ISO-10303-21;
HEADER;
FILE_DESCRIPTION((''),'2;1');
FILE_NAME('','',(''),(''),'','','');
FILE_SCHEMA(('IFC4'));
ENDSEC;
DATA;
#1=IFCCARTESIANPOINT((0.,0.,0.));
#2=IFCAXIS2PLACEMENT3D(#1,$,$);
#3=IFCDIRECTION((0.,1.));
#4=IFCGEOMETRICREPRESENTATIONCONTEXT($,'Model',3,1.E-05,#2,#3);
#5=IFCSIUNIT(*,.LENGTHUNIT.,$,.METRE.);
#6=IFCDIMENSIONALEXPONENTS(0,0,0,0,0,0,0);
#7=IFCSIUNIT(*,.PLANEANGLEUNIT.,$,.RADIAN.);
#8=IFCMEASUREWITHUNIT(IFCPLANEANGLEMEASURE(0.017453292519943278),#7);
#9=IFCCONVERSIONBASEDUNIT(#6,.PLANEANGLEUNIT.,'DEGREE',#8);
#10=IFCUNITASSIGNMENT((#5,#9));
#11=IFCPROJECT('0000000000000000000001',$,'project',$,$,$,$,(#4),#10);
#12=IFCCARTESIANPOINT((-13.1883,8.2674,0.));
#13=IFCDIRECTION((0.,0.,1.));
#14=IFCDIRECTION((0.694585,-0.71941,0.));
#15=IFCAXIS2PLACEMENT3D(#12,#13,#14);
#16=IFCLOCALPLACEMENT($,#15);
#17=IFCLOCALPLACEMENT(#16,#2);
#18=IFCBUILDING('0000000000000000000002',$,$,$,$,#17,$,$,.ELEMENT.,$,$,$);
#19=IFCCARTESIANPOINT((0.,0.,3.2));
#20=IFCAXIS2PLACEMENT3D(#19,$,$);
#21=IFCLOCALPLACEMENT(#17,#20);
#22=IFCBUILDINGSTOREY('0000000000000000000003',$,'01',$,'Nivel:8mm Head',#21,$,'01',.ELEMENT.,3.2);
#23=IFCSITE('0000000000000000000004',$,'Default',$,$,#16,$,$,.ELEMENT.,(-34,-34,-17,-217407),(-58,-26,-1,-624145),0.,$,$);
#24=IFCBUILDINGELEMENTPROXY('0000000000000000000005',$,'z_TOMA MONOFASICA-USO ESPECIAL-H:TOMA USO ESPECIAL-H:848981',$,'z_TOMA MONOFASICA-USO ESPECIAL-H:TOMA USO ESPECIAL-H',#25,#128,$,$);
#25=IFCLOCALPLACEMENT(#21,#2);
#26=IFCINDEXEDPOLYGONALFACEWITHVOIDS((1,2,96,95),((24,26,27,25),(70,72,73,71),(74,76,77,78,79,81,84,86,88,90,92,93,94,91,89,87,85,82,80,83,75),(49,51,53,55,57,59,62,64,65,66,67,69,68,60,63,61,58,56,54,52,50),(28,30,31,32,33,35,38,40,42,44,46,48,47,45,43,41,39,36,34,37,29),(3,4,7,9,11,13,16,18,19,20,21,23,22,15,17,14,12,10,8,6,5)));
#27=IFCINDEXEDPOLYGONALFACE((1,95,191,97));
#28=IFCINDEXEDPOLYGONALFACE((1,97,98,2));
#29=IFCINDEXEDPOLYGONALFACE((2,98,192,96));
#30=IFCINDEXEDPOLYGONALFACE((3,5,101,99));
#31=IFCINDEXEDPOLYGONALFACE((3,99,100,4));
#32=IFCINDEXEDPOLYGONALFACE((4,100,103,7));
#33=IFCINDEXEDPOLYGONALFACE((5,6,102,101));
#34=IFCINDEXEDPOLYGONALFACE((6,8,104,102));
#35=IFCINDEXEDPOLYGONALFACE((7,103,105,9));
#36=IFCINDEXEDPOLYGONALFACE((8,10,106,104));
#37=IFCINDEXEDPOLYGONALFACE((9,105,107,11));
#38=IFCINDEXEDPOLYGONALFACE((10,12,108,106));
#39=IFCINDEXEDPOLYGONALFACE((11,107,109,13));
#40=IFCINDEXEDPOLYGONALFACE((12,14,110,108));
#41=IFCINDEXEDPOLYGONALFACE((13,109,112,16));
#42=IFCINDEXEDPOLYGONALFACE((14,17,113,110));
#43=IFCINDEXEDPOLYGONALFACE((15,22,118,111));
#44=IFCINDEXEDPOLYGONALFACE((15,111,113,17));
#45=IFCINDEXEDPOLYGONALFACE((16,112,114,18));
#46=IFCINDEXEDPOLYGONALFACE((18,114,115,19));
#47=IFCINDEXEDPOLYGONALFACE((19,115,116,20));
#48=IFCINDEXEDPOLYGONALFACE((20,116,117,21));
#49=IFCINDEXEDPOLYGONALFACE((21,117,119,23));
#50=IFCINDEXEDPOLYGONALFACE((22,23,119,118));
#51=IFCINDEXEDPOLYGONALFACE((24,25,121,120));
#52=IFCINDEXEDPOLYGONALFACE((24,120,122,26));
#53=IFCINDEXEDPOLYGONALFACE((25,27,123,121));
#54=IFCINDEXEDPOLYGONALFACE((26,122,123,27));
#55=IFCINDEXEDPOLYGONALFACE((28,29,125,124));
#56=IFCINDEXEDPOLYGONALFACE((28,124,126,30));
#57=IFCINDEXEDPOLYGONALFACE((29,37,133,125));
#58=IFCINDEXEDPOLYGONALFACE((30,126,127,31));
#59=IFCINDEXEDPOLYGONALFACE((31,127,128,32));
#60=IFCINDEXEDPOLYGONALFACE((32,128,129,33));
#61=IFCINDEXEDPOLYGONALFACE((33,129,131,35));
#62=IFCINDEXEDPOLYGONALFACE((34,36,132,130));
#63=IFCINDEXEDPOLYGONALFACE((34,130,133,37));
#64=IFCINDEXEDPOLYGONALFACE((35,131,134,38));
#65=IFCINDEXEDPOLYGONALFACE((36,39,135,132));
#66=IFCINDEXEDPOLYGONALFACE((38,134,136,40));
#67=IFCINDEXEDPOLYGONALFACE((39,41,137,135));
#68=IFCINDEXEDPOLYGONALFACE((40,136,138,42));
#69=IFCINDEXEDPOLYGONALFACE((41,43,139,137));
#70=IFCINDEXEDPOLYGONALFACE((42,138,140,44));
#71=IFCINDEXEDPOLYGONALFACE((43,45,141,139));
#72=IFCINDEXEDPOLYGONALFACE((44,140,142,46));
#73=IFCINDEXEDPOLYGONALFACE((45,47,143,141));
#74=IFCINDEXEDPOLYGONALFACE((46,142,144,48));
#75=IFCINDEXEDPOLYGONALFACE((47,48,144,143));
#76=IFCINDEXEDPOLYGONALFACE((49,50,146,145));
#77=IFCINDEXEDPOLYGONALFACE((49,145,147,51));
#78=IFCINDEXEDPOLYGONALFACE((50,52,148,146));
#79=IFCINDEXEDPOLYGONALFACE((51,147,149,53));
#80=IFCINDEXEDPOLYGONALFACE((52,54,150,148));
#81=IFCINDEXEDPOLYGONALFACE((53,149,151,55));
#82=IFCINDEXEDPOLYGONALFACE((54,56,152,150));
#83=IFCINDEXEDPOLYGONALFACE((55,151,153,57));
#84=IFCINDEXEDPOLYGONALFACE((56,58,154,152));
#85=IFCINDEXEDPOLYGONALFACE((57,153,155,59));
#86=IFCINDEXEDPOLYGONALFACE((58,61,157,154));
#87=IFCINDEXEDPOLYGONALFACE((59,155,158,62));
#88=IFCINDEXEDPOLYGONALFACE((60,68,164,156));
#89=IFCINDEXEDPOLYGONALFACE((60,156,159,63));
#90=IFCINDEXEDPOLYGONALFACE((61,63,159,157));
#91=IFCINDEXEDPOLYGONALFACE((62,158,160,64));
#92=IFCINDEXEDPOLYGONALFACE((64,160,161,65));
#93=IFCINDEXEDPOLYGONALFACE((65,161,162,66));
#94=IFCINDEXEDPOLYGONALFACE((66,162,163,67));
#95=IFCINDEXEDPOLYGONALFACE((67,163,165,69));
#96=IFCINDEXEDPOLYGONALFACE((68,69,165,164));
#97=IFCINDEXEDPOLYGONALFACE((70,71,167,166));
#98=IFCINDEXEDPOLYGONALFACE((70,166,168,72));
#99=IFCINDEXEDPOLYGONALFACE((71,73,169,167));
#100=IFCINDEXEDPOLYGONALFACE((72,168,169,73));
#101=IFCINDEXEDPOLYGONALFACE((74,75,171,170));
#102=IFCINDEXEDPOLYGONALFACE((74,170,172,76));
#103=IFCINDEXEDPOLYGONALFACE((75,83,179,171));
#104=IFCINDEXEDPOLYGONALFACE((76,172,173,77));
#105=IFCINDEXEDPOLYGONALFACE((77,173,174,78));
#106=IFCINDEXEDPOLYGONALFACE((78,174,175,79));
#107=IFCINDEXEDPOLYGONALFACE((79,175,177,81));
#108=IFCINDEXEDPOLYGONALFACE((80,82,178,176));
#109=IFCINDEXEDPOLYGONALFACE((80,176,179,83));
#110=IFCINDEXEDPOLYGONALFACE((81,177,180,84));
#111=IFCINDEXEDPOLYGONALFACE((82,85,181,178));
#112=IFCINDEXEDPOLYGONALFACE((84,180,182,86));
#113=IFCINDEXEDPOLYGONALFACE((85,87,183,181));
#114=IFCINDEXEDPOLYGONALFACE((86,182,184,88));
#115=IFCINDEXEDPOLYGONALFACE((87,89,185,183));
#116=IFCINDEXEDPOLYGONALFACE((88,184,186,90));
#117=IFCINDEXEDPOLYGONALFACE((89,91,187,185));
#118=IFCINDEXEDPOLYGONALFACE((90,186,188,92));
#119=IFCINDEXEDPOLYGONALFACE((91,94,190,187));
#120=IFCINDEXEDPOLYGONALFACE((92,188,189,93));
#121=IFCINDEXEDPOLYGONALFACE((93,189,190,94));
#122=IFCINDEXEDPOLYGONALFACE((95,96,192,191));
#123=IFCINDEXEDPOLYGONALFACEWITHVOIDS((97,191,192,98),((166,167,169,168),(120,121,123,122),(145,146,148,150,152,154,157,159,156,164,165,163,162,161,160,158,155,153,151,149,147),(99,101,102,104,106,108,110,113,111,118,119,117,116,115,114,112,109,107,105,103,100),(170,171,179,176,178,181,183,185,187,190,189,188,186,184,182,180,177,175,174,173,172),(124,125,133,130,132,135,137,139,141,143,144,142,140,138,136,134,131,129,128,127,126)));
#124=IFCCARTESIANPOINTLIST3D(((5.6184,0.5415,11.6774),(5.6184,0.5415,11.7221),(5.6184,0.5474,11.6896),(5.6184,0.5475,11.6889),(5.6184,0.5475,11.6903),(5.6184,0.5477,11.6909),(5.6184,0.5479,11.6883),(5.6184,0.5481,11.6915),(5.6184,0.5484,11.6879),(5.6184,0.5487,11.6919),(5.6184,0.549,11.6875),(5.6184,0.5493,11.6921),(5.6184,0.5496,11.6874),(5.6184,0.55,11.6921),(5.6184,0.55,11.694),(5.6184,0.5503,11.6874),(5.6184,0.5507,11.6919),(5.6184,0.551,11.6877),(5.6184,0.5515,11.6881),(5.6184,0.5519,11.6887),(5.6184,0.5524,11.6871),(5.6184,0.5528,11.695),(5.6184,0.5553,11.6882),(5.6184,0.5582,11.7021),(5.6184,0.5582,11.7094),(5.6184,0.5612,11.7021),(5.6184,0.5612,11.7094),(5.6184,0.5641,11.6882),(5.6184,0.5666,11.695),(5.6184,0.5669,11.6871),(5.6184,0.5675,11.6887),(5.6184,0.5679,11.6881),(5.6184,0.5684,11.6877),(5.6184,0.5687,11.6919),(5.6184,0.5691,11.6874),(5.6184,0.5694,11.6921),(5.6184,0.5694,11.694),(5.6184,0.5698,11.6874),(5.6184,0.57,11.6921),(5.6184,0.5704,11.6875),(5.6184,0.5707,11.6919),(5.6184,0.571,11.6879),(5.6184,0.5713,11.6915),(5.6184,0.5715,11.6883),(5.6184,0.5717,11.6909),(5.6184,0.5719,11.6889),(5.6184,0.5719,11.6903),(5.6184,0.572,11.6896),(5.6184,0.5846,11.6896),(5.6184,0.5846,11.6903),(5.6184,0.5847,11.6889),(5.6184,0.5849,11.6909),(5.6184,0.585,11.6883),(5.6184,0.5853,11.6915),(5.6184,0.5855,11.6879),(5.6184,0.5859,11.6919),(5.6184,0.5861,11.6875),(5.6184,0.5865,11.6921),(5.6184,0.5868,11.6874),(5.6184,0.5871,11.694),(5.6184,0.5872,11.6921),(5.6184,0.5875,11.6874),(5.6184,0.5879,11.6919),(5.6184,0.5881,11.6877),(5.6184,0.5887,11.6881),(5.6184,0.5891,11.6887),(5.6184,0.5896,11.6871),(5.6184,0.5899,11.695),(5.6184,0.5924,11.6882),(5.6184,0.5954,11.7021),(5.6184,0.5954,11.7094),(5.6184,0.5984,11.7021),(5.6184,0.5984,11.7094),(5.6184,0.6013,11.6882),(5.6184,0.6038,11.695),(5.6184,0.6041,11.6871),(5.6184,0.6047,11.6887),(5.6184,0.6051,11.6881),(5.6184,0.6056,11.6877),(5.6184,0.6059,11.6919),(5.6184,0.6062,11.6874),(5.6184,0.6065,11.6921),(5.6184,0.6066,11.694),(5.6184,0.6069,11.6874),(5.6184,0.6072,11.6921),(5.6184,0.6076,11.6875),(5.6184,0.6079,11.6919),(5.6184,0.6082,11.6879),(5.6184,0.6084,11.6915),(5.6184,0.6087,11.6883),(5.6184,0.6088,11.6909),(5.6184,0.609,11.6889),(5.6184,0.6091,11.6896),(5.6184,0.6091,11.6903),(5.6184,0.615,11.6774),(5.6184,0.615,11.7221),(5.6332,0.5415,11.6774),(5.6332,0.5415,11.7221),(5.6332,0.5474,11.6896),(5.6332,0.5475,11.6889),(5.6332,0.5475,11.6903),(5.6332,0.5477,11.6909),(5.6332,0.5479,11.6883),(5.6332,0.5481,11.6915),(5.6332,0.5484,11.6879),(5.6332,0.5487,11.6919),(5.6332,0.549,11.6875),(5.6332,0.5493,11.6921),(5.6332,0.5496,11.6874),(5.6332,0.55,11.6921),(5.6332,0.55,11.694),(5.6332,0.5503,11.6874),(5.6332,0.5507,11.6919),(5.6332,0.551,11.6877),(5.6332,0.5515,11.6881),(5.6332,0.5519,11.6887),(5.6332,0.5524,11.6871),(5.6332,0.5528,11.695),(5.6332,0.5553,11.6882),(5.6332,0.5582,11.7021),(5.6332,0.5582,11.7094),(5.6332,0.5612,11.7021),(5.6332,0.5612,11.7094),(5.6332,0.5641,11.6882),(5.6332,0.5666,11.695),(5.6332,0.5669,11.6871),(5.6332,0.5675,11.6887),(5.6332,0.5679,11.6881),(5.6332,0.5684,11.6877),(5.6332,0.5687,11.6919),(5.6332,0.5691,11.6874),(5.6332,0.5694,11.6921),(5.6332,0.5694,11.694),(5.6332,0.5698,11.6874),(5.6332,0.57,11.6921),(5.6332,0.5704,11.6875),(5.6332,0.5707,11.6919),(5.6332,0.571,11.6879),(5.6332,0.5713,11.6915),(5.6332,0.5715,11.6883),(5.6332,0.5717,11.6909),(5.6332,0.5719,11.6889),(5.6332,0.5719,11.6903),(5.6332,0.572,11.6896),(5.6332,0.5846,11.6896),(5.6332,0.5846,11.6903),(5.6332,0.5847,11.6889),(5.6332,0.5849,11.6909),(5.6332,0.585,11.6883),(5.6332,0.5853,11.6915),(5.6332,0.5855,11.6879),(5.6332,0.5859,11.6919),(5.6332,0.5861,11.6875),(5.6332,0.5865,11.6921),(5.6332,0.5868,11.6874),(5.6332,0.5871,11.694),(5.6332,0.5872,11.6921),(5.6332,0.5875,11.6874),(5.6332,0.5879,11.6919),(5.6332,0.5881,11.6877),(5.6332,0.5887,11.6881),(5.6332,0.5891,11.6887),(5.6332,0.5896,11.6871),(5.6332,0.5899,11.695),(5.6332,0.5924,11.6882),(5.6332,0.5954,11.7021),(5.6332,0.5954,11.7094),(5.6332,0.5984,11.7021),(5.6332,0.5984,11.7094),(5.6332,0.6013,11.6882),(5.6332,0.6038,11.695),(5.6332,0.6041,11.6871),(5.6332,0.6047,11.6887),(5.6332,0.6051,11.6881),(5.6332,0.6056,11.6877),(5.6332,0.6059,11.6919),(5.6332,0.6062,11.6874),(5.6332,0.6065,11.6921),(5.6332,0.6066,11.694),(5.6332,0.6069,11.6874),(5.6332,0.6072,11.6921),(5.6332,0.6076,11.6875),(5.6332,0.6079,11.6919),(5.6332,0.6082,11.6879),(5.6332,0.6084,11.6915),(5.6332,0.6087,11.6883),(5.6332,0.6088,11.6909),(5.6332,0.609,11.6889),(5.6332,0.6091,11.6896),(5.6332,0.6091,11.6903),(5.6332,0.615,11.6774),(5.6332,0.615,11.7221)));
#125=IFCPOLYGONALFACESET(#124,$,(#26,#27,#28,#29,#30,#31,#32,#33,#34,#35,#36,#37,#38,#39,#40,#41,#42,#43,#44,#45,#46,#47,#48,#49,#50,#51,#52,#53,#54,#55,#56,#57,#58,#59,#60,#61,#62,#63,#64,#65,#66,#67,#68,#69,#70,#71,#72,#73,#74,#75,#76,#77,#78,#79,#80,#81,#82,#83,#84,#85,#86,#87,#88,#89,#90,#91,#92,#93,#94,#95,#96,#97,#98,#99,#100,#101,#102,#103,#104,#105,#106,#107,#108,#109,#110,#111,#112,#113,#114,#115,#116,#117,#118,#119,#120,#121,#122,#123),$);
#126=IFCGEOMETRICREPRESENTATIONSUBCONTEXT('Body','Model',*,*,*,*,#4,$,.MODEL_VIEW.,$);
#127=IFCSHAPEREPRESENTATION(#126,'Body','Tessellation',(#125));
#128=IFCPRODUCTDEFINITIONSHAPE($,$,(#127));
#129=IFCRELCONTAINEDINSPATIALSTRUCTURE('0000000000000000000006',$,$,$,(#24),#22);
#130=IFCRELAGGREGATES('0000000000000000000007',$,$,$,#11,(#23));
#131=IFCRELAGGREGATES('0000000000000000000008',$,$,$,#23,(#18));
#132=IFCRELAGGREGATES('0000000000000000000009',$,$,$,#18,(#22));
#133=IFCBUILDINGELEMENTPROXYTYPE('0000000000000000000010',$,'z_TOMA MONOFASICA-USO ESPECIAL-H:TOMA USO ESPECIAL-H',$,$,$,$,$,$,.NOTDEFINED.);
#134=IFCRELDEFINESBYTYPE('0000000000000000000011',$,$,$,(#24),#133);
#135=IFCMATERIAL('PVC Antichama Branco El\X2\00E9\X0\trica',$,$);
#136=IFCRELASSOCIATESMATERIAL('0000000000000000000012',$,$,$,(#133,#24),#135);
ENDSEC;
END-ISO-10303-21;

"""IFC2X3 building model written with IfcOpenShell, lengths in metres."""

from ifc_helpers import new_model, entity, si_unit, converted_unit, direction, frame, frame_2d, origin, place, context, subcontext, project, spatial, polyline, circle_curve, parameter, trimmed, segment, composite_curve, outline, extrude, source, transform, mapped, material, type_object, type_shapes, element, save


model = new_model("IFC2X3")

# Units and contexts
model_context = context("Model", 3, precision=1e-05, world=origin(), true_north=direction((0.0, 1.0)))
body_context = subcontext(model_context, "Body", "Model", "MODEL_VIEW")
ifc_project = project(units=[si_unit("LENGTHUNIT", "METRE"), converted_unit("PLANEANGLEUNIT", "DEGREE", entity("IfcPlaneAngleMeasure", 0.017453292519943278), si_unit("PLANEANGLEUNIT", "RADIAN"), dimensions=[0, 0, 0, 0, 0, 0, 0])], contexts=[model_context])

# Site, building, storey
site_placement = place(None, frame((-13.1883, 8.2674, 0.0), z_axis=(0.0, 0.0, 1.0), x_axis=(0.694585, -0.71941, 0.0)))
site = spatial("IfcSite", under=ifc_project, at=site_placement, Name="Default", CompositionType="ELEMENT", RefLatitude=(-34, -34, -17, -217407), RefLongitude=(-58, -26, -1, -624145), RefElevation=0.0)
building_placement = place(site_placement, origin())
building = spatial("IfcBuilding", under=site, at=building_placement, CompositionType="ELEMENT")
storey_placement = place(building_placement, frame((0.0, 0.0, 3.2)))
storey = spatial("IfcBuildingStorey", under=building, at=storey_placement, Name="01", ObjectType="Nivel:8mm Head", LongName="01", CompositionType="ELEMENT", Elevation=3.2)

# Building element proxy
ifc_material_1 = material(Name="PVC Antichama Branco Elétrica")
building_element_proxy_type_1 = type_object("IfcBuildingElementProxyType", Name="z_TOMA MONOFASICA-USO ESPECIAL-H:TOMA USO ESPECIAL-H", PredefinedType="NOTDEFINED", material=ifc_material_1)
shared_shape_1 = source(origin(), body_context, "Body", "SweptSolid", [
    extrude(outline(polyline([(-0.0368, -0.0223), (0.0368, -0.0223), (0.0368, 0.0223), (-0.0368, 0.0223), (-0.0368, -0.0223)]), holes=[composite_curve([segment(polyline([(0.0141, 0.0115), (0.0116, 0.0047)]), True, "CONTINUOUS"), segment(polyline([(0.0116, 0.0047), (0.0088, 0.0057)]), True, "CONTINUOUS"), segment(polyline([(0.0088, 0.0057), (0.0096, 0.0078)]), True, "CONTINUOUS"), segment(trimmed(circle_curve(frame_2d((0.0087, 0.0099), x_axis=(1.0, 0.0)), 0.0024), [parameter(27.118901)], [parameter(292.881099)], True, "PARAMETER"), False, "CONTINUOUS"), segment(polyline([(0.0108, 0.011), (0.0113, 0.0126)]), True, "CONTINUOUS"), segment(polyline([(0.0113, 0.0126), (0.0141, 0.0115)]), True, "CONTINUOUS")], self_intersect=False), composite_curve([segment(polyline([(0.0255, 0.0047), (0.023, 0.0115)]), True, "CONTINUOUS"), segment(polyline([(0.023, 0.0115), (0.0258, 0.0126)]), True, "CONTINUOUS"), segment(polyline([(0.0258, 0.0126), (0.0264, 0.011)]), True, "CONTINUOUS"), segment(trimmed(circle_curve(frame_2d((0.0285, 0.0099), x_axis=(1.0, 0.0)), 0.0024), [parameter(247.118901)], [parameter(152.881099)], True, "PARAMETER"), False, "CONTINUOUS"), segment(polyline([(0.0276, 0.0078), (0.0283, 0.0057)]), True, "CONTINUOUS"), segment(polyline([(0.0283, 0.0057), (0.0255, 0.0047)]), True, "CONTINUOUS")], self_intersect=False), polyline([(0.0201, -0.0024), (0.0201, -0.0097), (0.0171, -0.0097), (0.0171, -0.0024), (0.0201, -0.0024)]), composite_curve([segment(polyline([(-0.0141, 0.0115), (-0.0113, 0.0126)]), True, "CONTINUOUS"), segment(polyline([(-0.0113, 0.0126), (-0.0108, 0.011)]), True, "CONTINUOUS"), segment(trimmed(circle_curve(frame_2d((-0.0087, 0.0099), x_axis=(1.0, 0.0)), 0.0024), [parameter(247.118901)], [parameter(152.881099)], True, "PARAMETER"), False, "CONTINUOUS"), segment(polyline([(-0.0096, 0.0078), (-0.0088, 0.0057)]), True, "CONTINUOUS"), segment(polyline([(-0.0088, 0.0057), (-0.0116, 0.0047)]), True, "CONTINUOUS"), segment(polyline([(-0.0116, 0.0047), (-0.0141, 0.0115)]), True, "CONTINUOUS")], self_intersect=False), composite_curve([segment(polyline([(-0.0255, 0.0047), (-0.0283, 0.0057)]), True, "CONTINUOUS"), segment(polyline([(-0.0283, 0.0057), (-0.0276, 0.0078)]), True, "CONTINUOUS"), segment(trimmed(circle_curve(frame_2d((-0.0285, 0.0099), x_axis=(1.0, 0.0)), 0.0024), [parameter(27.118901)], [parameter(292.881099)], True, "PARAMETER"), False, "CONTINUOUS"), segment(polyline([(-0.0264, 0.011), (-0.0258, 0.0126)]), True, "CONTINUOUS"), segment(polyline([(-0.0258, 0.0126), (-0.023, 0.0115)]), True, "CONTINUOUS"), segment(polyline([(-0.023, 0.0115), (-0.0255, 0.0047)]), True, "CONTINUOUS")], self_intersect=False), polyline([(-0.0201, -0.0024), (-0.0171, -0.0024), (-0.0171, -0.0097), (-0.0201, -0.0097), (-0.0201, -0.0024)])]), frame((0.0, -0.005, 0.0223), z_axis=(0.0, 1.0, 0.0), x_axis=(1.0, 0.0, 0.0)), (0.0, 0.0, 1.0), 0.0148),
])
type_shapes(building_element_proxy_type_1, [shared_shape_1])
for number, where, z_axis, x_axis, name in (
    (1, (5.6282, 0.5783, 11.6774), (0.0, 0.0, 1.0), (0.0, 1.0, 0.0), "z_TOMA MONOFASICA-USO ESPECIAL-H:TOMA USO ESPECIAL-H:848981"),
):
    element("IfcBuildingElementProxy", number, at=place(storey_placement, frame(where, z_axis=z_axis, x_axis=x_axis)), inside=storey, type_object=building_element_proxy_type_1, material=ifc_material_1, Name=name, ObjectType="z_TOMA MONOFASICA-USO ESPECIAL-H:TOMA USO ESPECIAL-H", context=body_context, shape_type="MappedRepresentation", body=[
        mapped(shared_shape_1, transform((0.0, 0.0, 0.0), scale=1.0)),
    ])

save(model, "model.ifc")
